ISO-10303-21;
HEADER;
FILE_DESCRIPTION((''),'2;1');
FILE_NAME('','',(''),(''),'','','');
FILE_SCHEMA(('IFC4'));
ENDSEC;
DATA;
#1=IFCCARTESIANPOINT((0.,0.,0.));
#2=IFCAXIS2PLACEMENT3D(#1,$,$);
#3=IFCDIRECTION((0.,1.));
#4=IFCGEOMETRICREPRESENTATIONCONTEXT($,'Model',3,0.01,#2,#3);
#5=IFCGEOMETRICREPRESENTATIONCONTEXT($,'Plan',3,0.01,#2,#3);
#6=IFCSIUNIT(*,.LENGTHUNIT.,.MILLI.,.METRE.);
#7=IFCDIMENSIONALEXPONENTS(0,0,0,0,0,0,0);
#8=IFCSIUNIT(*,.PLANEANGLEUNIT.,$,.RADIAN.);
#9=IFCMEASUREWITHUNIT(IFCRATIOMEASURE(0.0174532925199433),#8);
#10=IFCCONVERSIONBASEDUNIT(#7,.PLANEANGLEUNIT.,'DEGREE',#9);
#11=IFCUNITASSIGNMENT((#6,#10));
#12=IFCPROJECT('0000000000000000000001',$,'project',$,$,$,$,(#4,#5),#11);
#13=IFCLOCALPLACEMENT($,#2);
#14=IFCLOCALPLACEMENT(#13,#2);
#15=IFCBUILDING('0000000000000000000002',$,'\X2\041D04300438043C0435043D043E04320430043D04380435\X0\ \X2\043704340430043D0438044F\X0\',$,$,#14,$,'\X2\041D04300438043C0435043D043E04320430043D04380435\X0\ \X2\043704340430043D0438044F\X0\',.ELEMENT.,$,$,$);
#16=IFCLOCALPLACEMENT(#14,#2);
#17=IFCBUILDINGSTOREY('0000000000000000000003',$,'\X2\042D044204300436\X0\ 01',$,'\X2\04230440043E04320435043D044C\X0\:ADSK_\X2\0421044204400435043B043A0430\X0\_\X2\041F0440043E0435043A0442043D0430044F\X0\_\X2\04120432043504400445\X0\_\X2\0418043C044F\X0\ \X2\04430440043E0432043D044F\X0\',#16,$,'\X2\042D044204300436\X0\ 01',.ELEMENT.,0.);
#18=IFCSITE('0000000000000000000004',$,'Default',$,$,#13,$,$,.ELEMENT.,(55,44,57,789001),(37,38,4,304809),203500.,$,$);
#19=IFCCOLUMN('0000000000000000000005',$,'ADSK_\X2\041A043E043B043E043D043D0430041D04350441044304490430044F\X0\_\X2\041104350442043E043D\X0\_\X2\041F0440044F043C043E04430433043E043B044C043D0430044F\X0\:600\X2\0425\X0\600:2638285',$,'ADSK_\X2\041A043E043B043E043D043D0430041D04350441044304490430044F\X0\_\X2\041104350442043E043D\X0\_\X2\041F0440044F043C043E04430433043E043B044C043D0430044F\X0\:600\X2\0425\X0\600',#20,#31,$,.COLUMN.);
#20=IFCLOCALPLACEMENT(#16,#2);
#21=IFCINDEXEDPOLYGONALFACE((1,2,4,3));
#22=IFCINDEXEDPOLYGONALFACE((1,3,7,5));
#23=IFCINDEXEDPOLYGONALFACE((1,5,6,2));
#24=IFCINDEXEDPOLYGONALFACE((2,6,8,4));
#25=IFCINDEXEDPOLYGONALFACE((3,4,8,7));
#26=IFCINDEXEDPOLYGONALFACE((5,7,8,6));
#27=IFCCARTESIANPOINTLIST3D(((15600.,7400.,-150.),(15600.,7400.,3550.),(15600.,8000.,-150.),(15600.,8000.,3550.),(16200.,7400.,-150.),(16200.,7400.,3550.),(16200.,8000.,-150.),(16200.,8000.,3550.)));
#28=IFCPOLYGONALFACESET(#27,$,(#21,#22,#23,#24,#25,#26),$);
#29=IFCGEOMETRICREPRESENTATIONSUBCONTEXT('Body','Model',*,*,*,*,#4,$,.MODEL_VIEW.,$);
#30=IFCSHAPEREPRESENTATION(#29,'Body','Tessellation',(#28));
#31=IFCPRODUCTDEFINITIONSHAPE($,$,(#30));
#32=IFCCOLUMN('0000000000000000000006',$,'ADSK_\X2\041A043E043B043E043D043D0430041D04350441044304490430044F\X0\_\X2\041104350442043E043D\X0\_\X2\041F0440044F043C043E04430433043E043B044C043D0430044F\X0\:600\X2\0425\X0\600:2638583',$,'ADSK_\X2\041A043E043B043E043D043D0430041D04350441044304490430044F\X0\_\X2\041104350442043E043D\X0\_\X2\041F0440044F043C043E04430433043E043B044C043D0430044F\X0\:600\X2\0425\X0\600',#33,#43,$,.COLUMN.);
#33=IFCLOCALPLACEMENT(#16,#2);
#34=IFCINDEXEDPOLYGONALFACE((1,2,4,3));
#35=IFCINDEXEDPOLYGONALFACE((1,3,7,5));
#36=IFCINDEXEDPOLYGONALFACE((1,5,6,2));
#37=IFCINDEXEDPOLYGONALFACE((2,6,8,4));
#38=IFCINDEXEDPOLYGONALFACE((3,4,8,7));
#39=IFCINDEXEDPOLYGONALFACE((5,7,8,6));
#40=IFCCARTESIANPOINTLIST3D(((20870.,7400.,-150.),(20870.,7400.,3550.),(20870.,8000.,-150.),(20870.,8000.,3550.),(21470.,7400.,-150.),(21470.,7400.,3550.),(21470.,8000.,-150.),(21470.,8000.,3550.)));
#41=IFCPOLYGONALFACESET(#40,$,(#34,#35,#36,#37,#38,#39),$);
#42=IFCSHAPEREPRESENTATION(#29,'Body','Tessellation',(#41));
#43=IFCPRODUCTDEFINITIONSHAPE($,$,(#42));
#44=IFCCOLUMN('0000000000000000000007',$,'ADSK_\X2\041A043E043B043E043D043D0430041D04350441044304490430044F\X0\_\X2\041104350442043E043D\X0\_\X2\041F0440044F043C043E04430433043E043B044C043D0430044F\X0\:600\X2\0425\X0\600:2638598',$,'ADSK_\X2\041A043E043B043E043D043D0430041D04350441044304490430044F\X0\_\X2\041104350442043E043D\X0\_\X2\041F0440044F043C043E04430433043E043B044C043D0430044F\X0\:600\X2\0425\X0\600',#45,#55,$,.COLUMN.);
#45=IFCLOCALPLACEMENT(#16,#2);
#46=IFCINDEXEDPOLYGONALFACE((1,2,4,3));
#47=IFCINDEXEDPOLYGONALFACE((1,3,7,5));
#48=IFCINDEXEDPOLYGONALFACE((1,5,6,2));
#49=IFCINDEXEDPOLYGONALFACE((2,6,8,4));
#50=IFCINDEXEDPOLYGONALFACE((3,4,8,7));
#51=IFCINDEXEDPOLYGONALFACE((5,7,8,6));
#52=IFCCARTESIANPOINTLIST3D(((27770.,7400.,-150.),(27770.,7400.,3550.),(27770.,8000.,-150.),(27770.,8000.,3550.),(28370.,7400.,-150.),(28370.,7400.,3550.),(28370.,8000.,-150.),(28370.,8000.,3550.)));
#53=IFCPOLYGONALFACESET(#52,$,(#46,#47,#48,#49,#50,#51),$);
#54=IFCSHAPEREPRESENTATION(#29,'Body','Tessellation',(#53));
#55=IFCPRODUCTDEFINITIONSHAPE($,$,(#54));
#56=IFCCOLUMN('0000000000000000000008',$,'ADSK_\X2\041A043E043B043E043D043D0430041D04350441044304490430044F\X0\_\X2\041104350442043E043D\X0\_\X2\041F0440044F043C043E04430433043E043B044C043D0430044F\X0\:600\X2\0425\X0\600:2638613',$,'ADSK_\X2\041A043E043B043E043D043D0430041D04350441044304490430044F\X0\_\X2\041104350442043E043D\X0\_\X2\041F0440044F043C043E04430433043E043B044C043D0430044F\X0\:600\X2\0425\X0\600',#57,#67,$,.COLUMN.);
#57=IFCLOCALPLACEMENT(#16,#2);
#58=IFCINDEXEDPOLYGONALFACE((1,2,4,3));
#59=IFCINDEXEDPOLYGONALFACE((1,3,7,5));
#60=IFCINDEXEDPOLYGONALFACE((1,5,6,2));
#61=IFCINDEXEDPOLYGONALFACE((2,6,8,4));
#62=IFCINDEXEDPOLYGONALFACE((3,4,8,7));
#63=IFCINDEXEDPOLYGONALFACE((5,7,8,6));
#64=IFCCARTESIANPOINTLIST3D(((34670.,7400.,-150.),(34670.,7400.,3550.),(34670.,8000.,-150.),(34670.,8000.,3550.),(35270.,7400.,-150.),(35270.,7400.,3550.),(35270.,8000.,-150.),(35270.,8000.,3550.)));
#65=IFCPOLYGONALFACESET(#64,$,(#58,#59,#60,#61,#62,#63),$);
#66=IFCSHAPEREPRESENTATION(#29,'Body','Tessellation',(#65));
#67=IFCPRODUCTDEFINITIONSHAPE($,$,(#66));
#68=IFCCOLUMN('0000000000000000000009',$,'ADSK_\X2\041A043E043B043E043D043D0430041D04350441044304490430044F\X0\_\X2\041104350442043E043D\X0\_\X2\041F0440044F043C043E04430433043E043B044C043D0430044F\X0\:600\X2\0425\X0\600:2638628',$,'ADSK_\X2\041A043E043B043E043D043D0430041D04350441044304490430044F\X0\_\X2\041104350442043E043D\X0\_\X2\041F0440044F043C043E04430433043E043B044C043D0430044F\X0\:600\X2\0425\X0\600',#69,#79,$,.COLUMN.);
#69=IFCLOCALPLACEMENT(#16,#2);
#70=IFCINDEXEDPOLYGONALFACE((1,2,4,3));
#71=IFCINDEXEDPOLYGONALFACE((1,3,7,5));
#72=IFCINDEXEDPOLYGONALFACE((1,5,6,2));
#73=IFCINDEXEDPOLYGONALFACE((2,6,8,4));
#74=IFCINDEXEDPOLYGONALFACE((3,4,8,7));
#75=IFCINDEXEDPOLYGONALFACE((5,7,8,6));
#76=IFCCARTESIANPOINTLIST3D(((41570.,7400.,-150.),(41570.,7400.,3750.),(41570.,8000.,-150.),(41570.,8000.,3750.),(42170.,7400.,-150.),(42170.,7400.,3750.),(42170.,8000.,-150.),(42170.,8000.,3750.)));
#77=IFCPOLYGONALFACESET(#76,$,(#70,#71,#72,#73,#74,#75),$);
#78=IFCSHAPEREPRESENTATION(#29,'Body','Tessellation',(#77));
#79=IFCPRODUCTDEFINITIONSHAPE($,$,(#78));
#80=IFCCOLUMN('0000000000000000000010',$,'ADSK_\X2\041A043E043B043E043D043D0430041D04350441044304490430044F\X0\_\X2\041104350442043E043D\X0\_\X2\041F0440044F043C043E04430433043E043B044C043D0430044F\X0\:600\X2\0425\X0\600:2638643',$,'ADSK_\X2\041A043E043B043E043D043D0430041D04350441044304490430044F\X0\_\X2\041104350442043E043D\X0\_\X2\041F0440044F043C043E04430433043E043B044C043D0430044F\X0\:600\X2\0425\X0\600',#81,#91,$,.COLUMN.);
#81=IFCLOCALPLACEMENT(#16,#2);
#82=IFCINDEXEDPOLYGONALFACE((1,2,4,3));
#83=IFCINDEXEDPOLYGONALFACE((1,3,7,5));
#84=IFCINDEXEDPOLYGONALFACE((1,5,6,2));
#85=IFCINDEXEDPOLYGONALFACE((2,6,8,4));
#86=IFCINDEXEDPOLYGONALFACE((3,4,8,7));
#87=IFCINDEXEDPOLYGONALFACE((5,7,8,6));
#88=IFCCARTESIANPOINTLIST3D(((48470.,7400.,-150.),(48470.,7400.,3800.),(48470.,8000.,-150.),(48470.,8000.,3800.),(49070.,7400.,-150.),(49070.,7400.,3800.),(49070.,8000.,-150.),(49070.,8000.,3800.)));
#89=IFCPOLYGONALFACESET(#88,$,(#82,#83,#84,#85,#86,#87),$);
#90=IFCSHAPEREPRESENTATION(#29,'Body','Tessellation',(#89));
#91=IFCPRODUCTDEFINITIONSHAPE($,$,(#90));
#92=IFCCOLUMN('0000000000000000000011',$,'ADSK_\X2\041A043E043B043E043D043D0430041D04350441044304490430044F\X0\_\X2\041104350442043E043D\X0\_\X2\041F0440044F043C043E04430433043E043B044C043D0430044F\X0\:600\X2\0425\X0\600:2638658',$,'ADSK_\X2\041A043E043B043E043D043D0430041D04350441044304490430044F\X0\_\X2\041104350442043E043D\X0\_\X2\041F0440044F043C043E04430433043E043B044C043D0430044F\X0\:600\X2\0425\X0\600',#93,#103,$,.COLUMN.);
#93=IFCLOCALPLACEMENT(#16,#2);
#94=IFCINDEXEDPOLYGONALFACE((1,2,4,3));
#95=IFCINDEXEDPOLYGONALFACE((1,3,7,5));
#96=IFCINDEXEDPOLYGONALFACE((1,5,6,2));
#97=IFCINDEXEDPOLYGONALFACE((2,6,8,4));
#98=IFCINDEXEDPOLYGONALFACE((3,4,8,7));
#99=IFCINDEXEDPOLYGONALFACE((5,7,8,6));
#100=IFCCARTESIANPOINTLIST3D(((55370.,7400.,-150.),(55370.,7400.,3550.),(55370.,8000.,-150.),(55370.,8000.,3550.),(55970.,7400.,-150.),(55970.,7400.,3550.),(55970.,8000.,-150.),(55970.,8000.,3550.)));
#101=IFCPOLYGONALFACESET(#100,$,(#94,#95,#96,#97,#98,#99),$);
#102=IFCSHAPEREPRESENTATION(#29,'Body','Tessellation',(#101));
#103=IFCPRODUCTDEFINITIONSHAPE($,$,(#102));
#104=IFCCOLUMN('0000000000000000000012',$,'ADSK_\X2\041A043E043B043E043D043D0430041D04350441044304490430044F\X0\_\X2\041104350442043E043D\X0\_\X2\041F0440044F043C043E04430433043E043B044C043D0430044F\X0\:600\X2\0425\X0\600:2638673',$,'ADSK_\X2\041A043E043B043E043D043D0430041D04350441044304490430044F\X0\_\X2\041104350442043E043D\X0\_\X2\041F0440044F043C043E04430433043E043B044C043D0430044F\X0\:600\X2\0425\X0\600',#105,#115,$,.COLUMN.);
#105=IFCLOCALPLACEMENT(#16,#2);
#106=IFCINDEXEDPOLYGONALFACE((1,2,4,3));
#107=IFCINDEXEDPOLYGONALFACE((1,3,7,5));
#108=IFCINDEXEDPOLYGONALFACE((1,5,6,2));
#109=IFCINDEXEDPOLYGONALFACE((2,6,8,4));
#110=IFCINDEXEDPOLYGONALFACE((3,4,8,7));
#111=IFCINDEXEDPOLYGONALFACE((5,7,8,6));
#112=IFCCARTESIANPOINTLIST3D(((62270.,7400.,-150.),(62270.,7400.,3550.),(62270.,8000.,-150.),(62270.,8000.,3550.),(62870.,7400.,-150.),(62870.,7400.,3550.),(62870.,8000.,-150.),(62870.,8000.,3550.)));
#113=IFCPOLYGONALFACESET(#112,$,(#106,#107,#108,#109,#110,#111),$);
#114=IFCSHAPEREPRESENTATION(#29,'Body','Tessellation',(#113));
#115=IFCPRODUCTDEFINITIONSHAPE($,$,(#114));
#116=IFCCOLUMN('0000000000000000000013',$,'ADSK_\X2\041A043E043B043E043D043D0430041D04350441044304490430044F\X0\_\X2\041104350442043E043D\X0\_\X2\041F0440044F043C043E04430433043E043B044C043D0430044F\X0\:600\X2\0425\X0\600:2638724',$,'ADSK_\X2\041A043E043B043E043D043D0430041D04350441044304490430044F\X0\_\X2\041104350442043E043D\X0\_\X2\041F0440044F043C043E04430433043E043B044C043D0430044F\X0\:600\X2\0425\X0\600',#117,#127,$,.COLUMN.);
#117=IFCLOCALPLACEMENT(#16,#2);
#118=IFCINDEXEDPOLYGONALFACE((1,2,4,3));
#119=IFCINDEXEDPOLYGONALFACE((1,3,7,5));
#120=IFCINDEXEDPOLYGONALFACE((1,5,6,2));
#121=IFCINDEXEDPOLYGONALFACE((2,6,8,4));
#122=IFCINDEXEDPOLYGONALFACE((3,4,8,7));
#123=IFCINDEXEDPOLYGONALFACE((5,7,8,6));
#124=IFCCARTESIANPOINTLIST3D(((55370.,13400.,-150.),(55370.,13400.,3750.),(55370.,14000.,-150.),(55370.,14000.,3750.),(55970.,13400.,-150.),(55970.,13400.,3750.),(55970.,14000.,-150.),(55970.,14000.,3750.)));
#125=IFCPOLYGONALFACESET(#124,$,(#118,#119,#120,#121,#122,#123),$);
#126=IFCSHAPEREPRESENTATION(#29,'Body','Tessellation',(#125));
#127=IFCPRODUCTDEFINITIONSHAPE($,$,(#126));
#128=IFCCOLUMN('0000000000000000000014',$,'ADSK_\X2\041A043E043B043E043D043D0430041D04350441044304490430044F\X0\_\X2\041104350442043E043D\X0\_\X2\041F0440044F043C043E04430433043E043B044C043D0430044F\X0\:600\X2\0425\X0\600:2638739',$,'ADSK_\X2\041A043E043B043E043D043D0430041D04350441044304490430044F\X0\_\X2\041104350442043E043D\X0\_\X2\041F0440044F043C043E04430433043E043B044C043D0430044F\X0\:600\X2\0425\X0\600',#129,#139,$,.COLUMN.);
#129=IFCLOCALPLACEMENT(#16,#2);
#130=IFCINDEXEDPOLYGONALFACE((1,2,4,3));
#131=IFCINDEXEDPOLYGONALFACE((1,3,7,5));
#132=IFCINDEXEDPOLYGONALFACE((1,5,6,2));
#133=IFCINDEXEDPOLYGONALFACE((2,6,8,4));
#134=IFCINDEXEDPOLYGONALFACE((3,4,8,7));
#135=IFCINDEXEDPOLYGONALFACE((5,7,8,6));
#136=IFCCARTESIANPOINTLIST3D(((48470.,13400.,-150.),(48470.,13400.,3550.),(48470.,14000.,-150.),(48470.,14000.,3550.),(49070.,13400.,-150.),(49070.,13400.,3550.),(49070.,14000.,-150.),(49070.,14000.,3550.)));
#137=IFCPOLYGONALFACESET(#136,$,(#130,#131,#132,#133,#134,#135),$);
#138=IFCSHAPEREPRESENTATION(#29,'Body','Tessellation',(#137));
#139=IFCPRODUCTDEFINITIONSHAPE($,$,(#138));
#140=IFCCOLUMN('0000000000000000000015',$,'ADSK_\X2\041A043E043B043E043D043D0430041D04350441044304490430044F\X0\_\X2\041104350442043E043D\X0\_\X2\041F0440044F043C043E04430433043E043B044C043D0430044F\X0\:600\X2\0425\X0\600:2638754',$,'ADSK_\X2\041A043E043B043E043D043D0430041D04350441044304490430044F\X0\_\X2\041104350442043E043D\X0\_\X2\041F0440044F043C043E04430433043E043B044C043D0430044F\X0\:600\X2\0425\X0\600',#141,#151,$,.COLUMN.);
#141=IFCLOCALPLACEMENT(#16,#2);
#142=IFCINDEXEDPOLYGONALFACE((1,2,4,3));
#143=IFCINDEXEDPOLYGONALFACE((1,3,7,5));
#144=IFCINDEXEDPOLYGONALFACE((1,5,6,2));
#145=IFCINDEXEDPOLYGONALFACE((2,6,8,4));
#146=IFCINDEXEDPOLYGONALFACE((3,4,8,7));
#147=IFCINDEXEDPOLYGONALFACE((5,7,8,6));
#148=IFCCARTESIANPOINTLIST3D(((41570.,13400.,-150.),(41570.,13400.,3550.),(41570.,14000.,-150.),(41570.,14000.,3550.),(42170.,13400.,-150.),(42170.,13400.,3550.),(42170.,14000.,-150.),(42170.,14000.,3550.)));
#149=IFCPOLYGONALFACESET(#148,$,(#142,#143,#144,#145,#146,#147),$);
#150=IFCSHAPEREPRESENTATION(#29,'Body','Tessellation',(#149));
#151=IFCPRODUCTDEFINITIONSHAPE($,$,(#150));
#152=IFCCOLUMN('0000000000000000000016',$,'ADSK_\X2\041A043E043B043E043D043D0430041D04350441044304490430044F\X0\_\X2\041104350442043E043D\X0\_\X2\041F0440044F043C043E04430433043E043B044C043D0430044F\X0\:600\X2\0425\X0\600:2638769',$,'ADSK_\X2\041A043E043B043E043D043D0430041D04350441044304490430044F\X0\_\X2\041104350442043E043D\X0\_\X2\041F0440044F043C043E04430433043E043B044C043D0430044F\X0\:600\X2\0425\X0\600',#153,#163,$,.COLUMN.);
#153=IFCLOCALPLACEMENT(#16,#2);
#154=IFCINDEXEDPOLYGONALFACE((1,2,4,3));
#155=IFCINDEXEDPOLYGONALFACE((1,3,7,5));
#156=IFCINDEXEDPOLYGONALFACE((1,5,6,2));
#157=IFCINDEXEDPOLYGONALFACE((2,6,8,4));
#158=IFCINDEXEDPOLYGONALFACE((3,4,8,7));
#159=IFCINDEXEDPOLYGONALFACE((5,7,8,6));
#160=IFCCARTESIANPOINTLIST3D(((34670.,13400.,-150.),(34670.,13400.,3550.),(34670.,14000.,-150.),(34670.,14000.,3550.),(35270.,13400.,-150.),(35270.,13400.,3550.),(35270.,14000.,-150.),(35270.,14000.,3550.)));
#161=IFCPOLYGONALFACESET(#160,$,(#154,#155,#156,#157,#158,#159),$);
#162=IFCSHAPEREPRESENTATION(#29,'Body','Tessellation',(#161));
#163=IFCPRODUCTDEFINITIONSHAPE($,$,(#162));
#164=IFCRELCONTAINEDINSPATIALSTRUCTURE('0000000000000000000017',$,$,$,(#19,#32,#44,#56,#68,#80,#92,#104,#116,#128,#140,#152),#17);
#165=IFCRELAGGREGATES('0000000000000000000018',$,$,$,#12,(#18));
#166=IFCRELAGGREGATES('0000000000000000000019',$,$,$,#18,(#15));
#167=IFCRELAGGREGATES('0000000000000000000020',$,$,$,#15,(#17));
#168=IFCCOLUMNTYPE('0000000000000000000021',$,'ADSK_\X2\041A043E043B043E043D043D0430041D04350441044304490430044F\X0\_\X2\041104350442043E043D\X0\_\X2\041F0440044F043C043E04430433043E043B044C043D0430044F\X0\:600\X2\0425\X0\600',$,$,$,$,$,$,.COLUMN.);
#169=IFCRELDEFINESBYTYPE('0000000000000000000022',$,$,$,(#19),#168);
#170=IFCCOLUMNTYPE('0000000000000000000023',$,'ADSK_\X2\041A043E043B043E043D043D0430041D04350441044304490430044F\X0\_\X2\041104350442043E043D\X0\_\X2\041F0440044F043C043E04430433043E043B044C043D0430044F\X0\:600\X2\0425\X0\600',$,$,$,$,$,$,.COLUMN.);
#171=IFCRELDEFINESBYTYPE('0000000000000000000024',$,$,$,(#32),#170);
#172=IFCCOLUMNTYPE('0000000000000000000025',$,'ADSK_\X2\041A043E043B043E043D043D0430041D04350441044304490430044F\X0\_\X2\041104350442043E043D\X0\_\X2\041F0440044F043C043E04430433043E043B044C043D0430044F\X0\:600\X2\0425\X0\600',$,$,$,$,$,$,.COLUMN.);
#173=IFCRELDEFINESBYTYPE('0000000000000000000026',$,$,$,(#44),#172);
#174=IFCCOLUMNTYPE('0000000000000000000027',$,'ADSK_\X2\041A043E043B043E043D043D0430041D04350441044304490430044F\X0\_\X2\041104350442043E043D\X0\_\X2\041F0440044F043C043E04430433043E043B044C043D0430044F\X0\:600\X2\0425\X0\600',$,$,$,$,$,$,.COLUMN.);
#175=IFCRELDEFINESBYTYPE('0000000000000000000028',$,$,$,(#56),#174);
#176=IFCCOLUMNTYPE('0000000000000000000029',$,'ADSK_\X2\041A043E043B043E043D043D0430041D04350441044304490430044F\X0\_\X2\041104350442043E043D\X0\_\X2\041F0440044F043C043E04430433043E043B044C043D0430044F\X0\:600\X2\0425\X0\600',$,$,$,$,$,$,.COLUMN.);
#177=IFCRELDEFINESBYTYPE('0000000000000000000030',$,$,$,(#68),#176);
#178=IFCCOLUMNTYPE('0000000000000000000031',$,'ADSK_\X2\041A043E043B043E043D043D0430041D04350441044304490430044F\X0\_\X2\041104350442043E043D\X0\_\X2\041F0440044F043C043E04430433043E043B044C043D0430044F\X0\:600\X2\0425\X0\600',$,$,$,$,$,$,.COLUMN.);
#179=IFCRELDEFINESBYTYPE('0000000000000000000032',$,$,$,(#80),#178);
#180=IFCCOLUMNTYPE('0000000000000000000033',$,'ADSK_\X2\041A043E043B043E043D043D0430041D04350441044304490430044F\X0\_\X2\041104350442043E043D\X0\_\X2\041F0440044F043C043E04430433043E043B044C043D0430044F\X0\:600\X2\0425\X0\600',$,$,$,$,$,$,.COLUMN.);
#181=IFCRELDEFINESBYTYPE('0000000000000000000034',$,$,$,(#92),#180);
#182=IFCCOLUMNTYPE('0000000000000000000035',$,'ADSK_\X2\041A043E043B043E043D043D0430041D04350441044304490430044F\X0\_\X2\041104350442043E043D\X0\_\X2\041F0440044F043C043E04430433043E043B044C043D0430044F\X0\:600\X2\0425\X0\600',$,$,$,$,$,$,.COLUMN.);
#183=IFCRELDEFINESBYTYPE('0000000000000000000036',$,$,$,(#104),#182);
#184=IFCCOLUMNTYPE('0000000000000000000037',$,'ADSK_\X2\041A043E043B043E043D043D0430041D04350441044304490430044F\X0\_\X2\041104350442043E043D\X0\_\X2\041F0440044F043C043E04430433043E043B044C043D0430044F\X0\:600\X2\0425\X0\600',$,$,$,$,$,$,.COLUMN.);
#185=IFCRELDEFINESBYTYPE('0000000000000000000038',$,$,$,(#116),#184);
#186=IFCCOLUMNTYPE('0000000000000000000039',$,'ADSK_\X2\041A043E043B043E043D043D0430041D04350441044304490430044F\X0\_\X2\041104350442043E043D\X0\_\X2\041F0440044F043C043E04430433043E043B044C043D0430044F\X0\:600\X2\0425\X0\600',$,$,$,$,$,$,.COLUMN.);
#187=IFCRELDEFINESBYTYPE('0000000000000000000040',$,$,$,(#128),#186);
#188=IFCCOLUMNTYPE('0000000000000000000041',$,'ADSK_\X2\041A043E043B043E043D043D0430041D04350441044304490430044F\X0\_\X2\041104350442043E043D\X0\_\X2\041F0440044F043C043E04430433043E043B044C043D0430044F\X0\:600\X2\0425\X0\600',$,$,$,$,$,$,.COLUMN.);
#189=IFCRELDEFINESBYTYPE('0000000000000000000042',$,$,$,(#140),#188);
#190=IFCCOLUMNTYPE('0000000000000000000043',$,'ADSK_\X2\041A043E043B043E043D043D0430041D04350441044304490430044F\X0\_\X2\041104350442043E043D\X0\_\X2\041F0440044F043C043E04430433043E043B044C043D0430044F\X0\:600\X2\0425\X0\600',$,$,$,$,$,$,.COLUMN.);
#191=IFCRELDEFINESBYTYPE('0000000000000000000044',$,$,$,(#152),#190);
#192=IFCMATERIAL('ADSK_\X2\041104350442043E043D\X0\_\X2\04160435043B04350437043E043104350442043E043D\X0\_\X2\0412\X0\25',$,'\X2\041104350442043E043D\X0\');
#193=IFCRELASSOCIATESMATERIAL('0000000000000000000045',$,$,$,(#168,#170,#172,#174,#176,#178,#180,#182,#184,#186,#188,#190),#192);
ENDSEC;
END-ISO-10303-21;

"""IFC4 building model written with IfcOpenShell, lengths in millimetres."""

from ifc_helpers import new_model, entity, si_unit, converted_unit, direction, frame, origin, place, context, subcontext, project, spatial, indexed_curve, outline, extrude, source, transform, mapped, material, type_object, type_shapes, element, save


model = new_model("IFC4")

# Units and contexts
model_context = context("Model", 3, precision=0.01, world=origin(), true_north=direction((0.0, 1.0)))
plan_context = context("Plan", 3, precision=0.01, world=origin(), true_north=direction((0.0, 1.0)))
body_context = subcontext(model_context, "Body", "Model", "MODEL_VIEW")
ifc_project = project(units=[si_unit("LENGTHUNIT", "METRE", prefix="MILLI"), converted_unit("PLANEANGLEUNIT", "DEGREE", entity("IfcRatioMeasure", 0.0174532925199433), si_unit("PLANEANGLEUNIT", "RADIAN"), dimensions=[0, 0, 0, 0, 0, 0, 0])], contexts=[model_context, plan_context])

# Site, building, storey
site_placement = place(None, origin())
site = spatial("IfcSite", under=ifc_project, at=site_placement, Name="Default", CompositionType="ELEMENT", RefLatitude=(55, 44, 57, 789001), RefLongitude=(37, 38, 4, 304809), RefElevation=203500.0)
building_placement = place(site_placement, origin())
building = spatial("IfcBuilding", under=site, at=building_placement, Name="Наименование здания", LongName="Наименование здания", CompositionType="ELEMENT")
storey_placement = place(building_placement, origin())
storey = spatial("IfcBuildingStorey", under=building, at=storey_placement, Name="Этаж 01", ObjectType="Уровень:ADSK_Стрелка_Проектная_Вверх_Имя уровня", LongName="Этаж 01", CompositionType="ELEMENT", Elevation=0.0)

# Columns
ifc_material = material(Name="ADSK_Бетон_Железобетон_В25", Category="Бетон")
column_type_1 = type_object("IfcColumnType", Name="ADSK_КолоннаНесущая_Бетон_Прямоугольная:600Х600", PredefinedType="COLUMN", material=ifc_material)
shared_shape_1 = source(origin(), body_context, "Body", "SweptSolid", [
    extrude(outline(indexed_curve([(-300.0, -300.0), (300.0, -300.0), (300.0, 300.0), (-300.0, 300.0), (-300.0, -300.0)], self_intersect=False)), frame((15900.0, 7700.0, -150.0), z_axis=(0.0, 0.0, 1.0), x_axis=(0.0, -1.0, 0.0)), (0.0, 0.0, 1.0), 3700.0),
])
type_shapes(column_type_1, [shared_shape_1])
placement = place(storey_placement, origin())
element("IfcColumn", 1, at=placement, inside=storey, type_object=column_type_1, Name="ADSK_КолоннаНесущая_Бетон_Прямоугольная:600Х600:2638285", ObjectType="ADSK_КолоннаНесущая_Бетон_Прямоугольная:600Х600", PredefinedType="COLUMN", context=body_context, shape_type="MappedRepresentation", body=[
    mapped(shared_shape_1, transform((0.0, 0.0, 0.0), scale=1.0)),
])
column_type_2 = type_object("IfcColumnType", Name="ADSK_КолоннаНесущая_Бетон_Прямоугольная:600Х600", PredefinedType="COLUMN", material=ifc_material)
shared_shape_2 = source(origin(), body_context, "Body", "SweptSolid", [
    extrude(outline(indexed_curve([(-300.0, -300.0), (300.0, -300.0), (300.0, 300.0), (-300.0, 300.0), (-300.0, -300.0)], self_intersect=False)), frame((21170.0, 7700.0, -150.0), z_axis=(0.0, 0.0, 1.0), x_axis=(0.0, -1.0, 0.0)), (0.0, 0.0, 1.0), 3700.0),
])
type_shapes(column_type_2, [shared_shape_2])
element("IfcColumn", 2, at=placement, inside=storey, type_object=column_type_2, Name="ADSK_КолоннаНесущая_Бетон_Прямоугольная:600Х600:2638583", ObjectType="ADSK_КолоннаНесущая_Бетон_Прямоугольная:600Х600", PredefinedType="COLUMN", context=body_context, shape_type="MappedRepresentation", body=[
    mapped(shared_shape_2, transform((0.0, 0.0, 0.0), scale=1.0)),
])
column_type_3 = type_object("IfcColumnType", Name="ADSK_КолоннаНесущая_Бетон_Прямоугольная:600Х600", PredefinedType="COLUMN", material=ifc_material)
shared_shape_3 = source(origin(), body_context, "Body", "SweptSolid", [
    extrude(outline(indexed_curve([(-300.0, -300.0), (300.0, -300.0), (300.0, 300.0), (-300.0, 300.0), (-300.0, -300.0)], self_intersect=False)), frame((28070.0, 7700.0, -150.0), z_axis=(0.0, 0.0, 1.0), x_axis=(0.0, -1.0, 0.0)), (0.0, 0.0, 1.0), 3700.0),
])
type_shapes(column_type_3, [shared_shape_3])
element("IfcColumn", 3, at=placement, inside=storey, type_object=column_type_3, Name="ADSK_КолоннаНесущая_Бетон_Прямоугольная:600Х600:2638598", ObjectType="ADSK_КолоннаНесущая_Бетон_Прямоугольная:600Х600", PredefinedType="COLUMN", context=body_context, shape_type="MappedRepresentation", body=[
    mapped(shared_shape_3, transform((0.0, 0.0, 0.0), scale=1.0)),
])
column_type_4 = type_object("IfcColumnType", Name="ADSK_КолоннаНесущая_Бетон_Прямоугольная:600Х600", PredefinedType="COLUMN", material=ifc_material)
shared_shape_4 = source(origin(), body_context, "Body", "SweptSolid", [
    extrude(outline(indexed_curve([(-300.0, -300.0), (300.0, -300.0), (300.0, 300.0), (-300.0, 300.0), (-300.0, -300.0)], self_intersect=False)), frame((34970.0, 7700.0, -150.0), z_axis=(0.0, 0.0, 1.0), x_axis=(0.0, -1.0, 0.0)), (0.0, 0.0, 1.0), 3700.0),
])
type_shapes(column_type_4, [shared_shape_4])
element("IfcColumn", 4, at=placement, inside=storey, type_object=column_type_4, Name="ADSK_КолоннаНесущая_Бетон_Прямоугольная:600Х600:2638613", ObjectType="ADSK_КолоннаНесущая_Бетон_Прямоугольная:600Х600", PredefinedType="COLUMN", context=body_context, shape_type="MappedRepresentation", body=[
    mapped(shared_shape_4, transform((0.0, 0.0, 0.0), scale=1.0)),
])
column_type_5 = type_object("IfcColumnType", Name="ADSK_КолоннаНесущая_Бетон_Прямоугольная:600Х600", PredefinedType="COLUMN", material=ifc_material)
shared_shape_5 = source(origin(), body_context, "Body", "SweptSolid", [
    extrude(outline(indexed_curve([(-300.0, -300.0), (300.0, -300.0), (300.0, 300.0), (-300.0, 300.0), (-300.0, -300.0)], self_intersect=False)), frame((41870.0, 7700.0, -150.0), z_axis=(0.0, 0.0, 1.0), x_axis=(0.0, -1.0, 0.0)), (0.0, 0.0, 1.0), 3900.0),
])
type_shapes(column_type_5, [shared_shape_5])
element("IfcColumn", 5, at=placement, inside=storey, type_object=column_type_5, Name="ADSK_КолоннаНесущая_Бетон_Прямоугольная:600Х600:2638628", ObjectType="ADSK_КолоннаНесущая_Бетон_Прямоугольная:600Х600", PredefinedType="COLUMN", context=body_context, shape_type="MappedRepresentation", body=[
    mapped(shared_shape_5, transform((0.0, 0.0, 0.0), scale=1.0)),
])
column_type_6 = type_object("IfcColumnType", Name="ADSK_КолоннаНесущая_Бетон_Прямоугольная:600Х600", PredefinedType="COLUMN", material=ifc_material)
shared_shape_6 = source(origin(), body_context, "Body", "SweptSolid", [
    extrude(outline(indexed_curve([(-300.0, -300.0), (300.0, -300.0), (300.0, 300.0), (-300.0, 300.0), (-300.0, -300.0)], self_intersect=False)), frame((48770.0, 7700.0, -150.0), z_axis=(0.0, 0.0, 1.0), x_axis=(0.0, -1.0, 0.0)), (0.0, 0.0, 1.0), 3950.0),
])
type_shapes(column_type_6, [shared_shape_6])
element("IfcColumn", 6, at=placement, inside=storey, type_object=column_type_6, Name="ADSK_КолоннаНесущая_Бетон_Прямоугольная:600Х600:2638643", ObjectType="ADSK_КолоннаНесущая_Бетон_Прямоугольная:600Х600", PredefinedType="COLUMN", context=body_context, shape_type="MappedRepresentation", body=[
    mapped(shared_shape_6, transform((0.0, 0.0, 0.0), scale=1.0)),
])
column_type_7 = type_object("IfcColumnType", Name="ADSK_КолоннаНесущая_Бетон_Прямоугольная:600Х600", PredefinedType="COLUMN", material=ifc_material)
shared_shape_7 = source(origin(), body_context, "Body", "SweptSolid", [
    extrude(outline(indexed_curve([(-300.0, -300.0), (300.0, -300.0), (300.0, 300.0), (-300.0, 300.0), (-300.0, -300.0)], self_intersect=False)), frame((55670.0, 7700.0, -150.0), z_axis=(0.0, 0.0, 1.0), x_axis=(0.0, -1.0, 0.0)), (0.0, 0.0, 1.0), 3700.0),
])
type_shapes(column_type_7, [shared_shape_7])
element("IfcColumn", 7, at=placement, inside=storey, type_object=column_type_7, Name="ADSK_КолоннаНесущая_Бетон_Прямоугольная:600Х600:2638658", ObjectType="ADSK_КолоннаНесущая_Бетон_Прямоугольная:600Х600", PredefinedType="COLUMN", context=body_context, shape_type="MappedRepresentation", body=[
    mapped(shared_shape_7, transform((0.0, 0.0, 0.0), scale=1.0)),
])
column_type_8 = type_object("IfcColumnType", Name="ADSK_КолоннаНесущая_Бетон_Прямоугольная:600Х600", PredefinedType="COLUMN", material=ifc_material)
shared_shape_8 = source(origin(), body_context, "Body", "SweptSolid", [
    extrude(outline(indexed_curve([(-300.0, -300.0), (300.0, -300.0), (300.0, 300.0), (-300.0, 300.0), (-300.0, -300.0)], self_intersect=False)), frame((62570.0, 7700.0, -150.0), z_axis=(0.0, 0.0, 1.0), x_axis=(0.0, -1.0, 0.0)), (0.0, 0.0, 1.0), 3700.0),
])
type_shapes(column_type_8, [shared_shape_8])
element("IfcColumn", 8, at=placement, inside=storey, type_object=column_type_8, Name="ADSK_КолоннаНесущая_Бетон_Прямоугольная:600Х600:2638673", ObjectType="ADSK_КолоннаНесущая_Бетон_Прямоугольная:600Х600", PredefinedType="COLUMN", context=body_context, shape_type="MappedRepresentation", body=[
    mapped(shared_shape_8, transform((0.0, 0.0, 0.0), scale=1.0)),
])
column_type_9 = type_object("IfcColumnType", Name="ADSK_КолоннаНесущая_Бетон_Прямоугольная:600Х600", PredefinedType="COLUMN", material=ifc_material)
shared_shape_9 = source(origin(), body_context, "Body", "SweptSolid", [
    extrude(outline(indexed_curve([(-300.0, -300.0), (300.0, -300.0), (300.0, 300.0), (-300.0, 300.0), (-300.0, -300.0)], self_intersect=False)), frame((55670.0, 13700.0, -150.0), z_axis=(0.0, 0.0, 1.0), x_axis=(0.0, -1.0, 0.0)), (0.0, 0.0, 1.0), 3900.0),
])
type_shapes(column_type_9, [shared_shape_9])
element("IfcColumn", 9, at=placement, inside=storey, type_object=column_type_9, Name="ADSK_КолоннаНесущая_Бетон_Прямоугольная:600Х600:2638724", ObjectType="ADSK_КолоннаНесущая_Бетон_Прямоугольная:600Х600", PredefinedType="COLUMN", context=body_context, shape_type="MappedRepresentation", body=[
    mapped(shared_shape_9, transform((0.0, 0.0, 0.0), scale=1.0)),
])
column_type_10 = type_object("IfcColumnType", Name="ADSK_КолоннаНесущая_Бетон_Прямоугольная:600Х600", PredefinedType="COLUMN", material=ifc_material)
shared_shape_10 = source(origin(), body_context, "Body", "SweptSolid", [
    extrude(outline(indexed_curve([(-300.0, -300.0), (300.0, -300.0), (300.0, 300.0), (-300.0, 300.0), (-300.0, -300.0)], self_intersect=False)), frame((48770.0, 13700.0, -150.0), z_axis=(0.0, 0.0, 1.0), x_axis=(0.0, -1.0, 0.0)), (0.0, 0.0, 1.0), 3700.0),
])
type_shapes(column_type_10, [shared_shape_10])
element("IfcColumn", 10, at=placement, inside=storey, type_object=column_type_10, Name="ADSK_КолоннаНесущая_Бетон_Прямоугольная:600Х600:2638739", ObjectType="ADSK_КолоннаНесущая_Бетон_Прямоугольная:600Х600", PredefinedType="COLUMN", context=body_context, shape_type="MappedRepresentation", body=[
    mapped(shared_shape_10, transform((0.0, 0.0, 0.0), scale=1.0)),
])
column_type_11 = type_object("IfcColumnType", Name="ADSK_КолоннаНесущая_Бетон_Прямоугольная:600Х600", PredefinedType="COLUMN", material=ifc_material)
shared_shape_11 = source(origin(), body_context, "Body", "SweptSolid", [
    extrude(outline(indexed_curve([(-300.0, -300.0), (300.0, -300.0), (300.0, 300.0), (-300.0, 300.0), (-300.0, -300.0)], self_intersect=False)), frame((41870.0, 13700.0, -150.0), z_axis=(0.0, 0.0, 1.0), x_axis=(0.0, -1.0, 0.0)), (0.0, 0.0, 1.0), 3700.0),
])
type_shapes(column_type_11, [shared_shape_11])
element("IfcColumn", 11, at=placement, inside=storey, type_object=column_type_11, Name="ADSK_КолоннаНесущая_Бетон_Прямоугольная:600Х600:2638754", ObjectType="ADSK_КолоннаНесущая_Бетон_Прямоугольная:600Х600", PredefinedType="COLUMN", context=body_context, shape_type="MappedRepresentation", body=[
    mapped(shared_shape_11, transform((0.0, 0.0, 0.0), scale=1.0)),
])
column_type_12 = type_object("IfcColumnType", Name="ADSK_КолоннаНесущая_Бетон_Прямоугольная:600Х600", PredefinedType="COLUMN", material=ifc_material)
shared_shape_12 = source(origin(), body_context, "Body", "SweptSolid", [
    extrude(outline(indexed_curve([(-300.0, -300.0), (300.0, -300.0), (300.0, 300.0), (-300.0, 300.0), (-300.0, -300.0)], self_intersect=False)), frame((34970.0, 13700.0, -150.0), z_axis=(0.0, 0.0, 1.0), x_axis=(0.0, -1.0, 0.0)), (0.0, 0.0, 1.0), 3700.0),
])
type_shapes(column_type_12, [shared_shape_12])
element("IfcColumn", 12, at=placement, inside=storey, type_object=column_type_12, Name="ADSK_КолоннаНесущая_Бетон_Прямоугольная:600Х600:2638769", ObjectType="ADSK_КолоннаНесущая_Бетон_Прямоугольная:600Х600", PredefinedType="COLUMN", context=body_context, shape_type="MappedRepresentation", body=[
    mapped(shared_shape_12, transform((0.0, 0.0, 0.0), scale=1.0)),
])

save(model, "model.ifc")
